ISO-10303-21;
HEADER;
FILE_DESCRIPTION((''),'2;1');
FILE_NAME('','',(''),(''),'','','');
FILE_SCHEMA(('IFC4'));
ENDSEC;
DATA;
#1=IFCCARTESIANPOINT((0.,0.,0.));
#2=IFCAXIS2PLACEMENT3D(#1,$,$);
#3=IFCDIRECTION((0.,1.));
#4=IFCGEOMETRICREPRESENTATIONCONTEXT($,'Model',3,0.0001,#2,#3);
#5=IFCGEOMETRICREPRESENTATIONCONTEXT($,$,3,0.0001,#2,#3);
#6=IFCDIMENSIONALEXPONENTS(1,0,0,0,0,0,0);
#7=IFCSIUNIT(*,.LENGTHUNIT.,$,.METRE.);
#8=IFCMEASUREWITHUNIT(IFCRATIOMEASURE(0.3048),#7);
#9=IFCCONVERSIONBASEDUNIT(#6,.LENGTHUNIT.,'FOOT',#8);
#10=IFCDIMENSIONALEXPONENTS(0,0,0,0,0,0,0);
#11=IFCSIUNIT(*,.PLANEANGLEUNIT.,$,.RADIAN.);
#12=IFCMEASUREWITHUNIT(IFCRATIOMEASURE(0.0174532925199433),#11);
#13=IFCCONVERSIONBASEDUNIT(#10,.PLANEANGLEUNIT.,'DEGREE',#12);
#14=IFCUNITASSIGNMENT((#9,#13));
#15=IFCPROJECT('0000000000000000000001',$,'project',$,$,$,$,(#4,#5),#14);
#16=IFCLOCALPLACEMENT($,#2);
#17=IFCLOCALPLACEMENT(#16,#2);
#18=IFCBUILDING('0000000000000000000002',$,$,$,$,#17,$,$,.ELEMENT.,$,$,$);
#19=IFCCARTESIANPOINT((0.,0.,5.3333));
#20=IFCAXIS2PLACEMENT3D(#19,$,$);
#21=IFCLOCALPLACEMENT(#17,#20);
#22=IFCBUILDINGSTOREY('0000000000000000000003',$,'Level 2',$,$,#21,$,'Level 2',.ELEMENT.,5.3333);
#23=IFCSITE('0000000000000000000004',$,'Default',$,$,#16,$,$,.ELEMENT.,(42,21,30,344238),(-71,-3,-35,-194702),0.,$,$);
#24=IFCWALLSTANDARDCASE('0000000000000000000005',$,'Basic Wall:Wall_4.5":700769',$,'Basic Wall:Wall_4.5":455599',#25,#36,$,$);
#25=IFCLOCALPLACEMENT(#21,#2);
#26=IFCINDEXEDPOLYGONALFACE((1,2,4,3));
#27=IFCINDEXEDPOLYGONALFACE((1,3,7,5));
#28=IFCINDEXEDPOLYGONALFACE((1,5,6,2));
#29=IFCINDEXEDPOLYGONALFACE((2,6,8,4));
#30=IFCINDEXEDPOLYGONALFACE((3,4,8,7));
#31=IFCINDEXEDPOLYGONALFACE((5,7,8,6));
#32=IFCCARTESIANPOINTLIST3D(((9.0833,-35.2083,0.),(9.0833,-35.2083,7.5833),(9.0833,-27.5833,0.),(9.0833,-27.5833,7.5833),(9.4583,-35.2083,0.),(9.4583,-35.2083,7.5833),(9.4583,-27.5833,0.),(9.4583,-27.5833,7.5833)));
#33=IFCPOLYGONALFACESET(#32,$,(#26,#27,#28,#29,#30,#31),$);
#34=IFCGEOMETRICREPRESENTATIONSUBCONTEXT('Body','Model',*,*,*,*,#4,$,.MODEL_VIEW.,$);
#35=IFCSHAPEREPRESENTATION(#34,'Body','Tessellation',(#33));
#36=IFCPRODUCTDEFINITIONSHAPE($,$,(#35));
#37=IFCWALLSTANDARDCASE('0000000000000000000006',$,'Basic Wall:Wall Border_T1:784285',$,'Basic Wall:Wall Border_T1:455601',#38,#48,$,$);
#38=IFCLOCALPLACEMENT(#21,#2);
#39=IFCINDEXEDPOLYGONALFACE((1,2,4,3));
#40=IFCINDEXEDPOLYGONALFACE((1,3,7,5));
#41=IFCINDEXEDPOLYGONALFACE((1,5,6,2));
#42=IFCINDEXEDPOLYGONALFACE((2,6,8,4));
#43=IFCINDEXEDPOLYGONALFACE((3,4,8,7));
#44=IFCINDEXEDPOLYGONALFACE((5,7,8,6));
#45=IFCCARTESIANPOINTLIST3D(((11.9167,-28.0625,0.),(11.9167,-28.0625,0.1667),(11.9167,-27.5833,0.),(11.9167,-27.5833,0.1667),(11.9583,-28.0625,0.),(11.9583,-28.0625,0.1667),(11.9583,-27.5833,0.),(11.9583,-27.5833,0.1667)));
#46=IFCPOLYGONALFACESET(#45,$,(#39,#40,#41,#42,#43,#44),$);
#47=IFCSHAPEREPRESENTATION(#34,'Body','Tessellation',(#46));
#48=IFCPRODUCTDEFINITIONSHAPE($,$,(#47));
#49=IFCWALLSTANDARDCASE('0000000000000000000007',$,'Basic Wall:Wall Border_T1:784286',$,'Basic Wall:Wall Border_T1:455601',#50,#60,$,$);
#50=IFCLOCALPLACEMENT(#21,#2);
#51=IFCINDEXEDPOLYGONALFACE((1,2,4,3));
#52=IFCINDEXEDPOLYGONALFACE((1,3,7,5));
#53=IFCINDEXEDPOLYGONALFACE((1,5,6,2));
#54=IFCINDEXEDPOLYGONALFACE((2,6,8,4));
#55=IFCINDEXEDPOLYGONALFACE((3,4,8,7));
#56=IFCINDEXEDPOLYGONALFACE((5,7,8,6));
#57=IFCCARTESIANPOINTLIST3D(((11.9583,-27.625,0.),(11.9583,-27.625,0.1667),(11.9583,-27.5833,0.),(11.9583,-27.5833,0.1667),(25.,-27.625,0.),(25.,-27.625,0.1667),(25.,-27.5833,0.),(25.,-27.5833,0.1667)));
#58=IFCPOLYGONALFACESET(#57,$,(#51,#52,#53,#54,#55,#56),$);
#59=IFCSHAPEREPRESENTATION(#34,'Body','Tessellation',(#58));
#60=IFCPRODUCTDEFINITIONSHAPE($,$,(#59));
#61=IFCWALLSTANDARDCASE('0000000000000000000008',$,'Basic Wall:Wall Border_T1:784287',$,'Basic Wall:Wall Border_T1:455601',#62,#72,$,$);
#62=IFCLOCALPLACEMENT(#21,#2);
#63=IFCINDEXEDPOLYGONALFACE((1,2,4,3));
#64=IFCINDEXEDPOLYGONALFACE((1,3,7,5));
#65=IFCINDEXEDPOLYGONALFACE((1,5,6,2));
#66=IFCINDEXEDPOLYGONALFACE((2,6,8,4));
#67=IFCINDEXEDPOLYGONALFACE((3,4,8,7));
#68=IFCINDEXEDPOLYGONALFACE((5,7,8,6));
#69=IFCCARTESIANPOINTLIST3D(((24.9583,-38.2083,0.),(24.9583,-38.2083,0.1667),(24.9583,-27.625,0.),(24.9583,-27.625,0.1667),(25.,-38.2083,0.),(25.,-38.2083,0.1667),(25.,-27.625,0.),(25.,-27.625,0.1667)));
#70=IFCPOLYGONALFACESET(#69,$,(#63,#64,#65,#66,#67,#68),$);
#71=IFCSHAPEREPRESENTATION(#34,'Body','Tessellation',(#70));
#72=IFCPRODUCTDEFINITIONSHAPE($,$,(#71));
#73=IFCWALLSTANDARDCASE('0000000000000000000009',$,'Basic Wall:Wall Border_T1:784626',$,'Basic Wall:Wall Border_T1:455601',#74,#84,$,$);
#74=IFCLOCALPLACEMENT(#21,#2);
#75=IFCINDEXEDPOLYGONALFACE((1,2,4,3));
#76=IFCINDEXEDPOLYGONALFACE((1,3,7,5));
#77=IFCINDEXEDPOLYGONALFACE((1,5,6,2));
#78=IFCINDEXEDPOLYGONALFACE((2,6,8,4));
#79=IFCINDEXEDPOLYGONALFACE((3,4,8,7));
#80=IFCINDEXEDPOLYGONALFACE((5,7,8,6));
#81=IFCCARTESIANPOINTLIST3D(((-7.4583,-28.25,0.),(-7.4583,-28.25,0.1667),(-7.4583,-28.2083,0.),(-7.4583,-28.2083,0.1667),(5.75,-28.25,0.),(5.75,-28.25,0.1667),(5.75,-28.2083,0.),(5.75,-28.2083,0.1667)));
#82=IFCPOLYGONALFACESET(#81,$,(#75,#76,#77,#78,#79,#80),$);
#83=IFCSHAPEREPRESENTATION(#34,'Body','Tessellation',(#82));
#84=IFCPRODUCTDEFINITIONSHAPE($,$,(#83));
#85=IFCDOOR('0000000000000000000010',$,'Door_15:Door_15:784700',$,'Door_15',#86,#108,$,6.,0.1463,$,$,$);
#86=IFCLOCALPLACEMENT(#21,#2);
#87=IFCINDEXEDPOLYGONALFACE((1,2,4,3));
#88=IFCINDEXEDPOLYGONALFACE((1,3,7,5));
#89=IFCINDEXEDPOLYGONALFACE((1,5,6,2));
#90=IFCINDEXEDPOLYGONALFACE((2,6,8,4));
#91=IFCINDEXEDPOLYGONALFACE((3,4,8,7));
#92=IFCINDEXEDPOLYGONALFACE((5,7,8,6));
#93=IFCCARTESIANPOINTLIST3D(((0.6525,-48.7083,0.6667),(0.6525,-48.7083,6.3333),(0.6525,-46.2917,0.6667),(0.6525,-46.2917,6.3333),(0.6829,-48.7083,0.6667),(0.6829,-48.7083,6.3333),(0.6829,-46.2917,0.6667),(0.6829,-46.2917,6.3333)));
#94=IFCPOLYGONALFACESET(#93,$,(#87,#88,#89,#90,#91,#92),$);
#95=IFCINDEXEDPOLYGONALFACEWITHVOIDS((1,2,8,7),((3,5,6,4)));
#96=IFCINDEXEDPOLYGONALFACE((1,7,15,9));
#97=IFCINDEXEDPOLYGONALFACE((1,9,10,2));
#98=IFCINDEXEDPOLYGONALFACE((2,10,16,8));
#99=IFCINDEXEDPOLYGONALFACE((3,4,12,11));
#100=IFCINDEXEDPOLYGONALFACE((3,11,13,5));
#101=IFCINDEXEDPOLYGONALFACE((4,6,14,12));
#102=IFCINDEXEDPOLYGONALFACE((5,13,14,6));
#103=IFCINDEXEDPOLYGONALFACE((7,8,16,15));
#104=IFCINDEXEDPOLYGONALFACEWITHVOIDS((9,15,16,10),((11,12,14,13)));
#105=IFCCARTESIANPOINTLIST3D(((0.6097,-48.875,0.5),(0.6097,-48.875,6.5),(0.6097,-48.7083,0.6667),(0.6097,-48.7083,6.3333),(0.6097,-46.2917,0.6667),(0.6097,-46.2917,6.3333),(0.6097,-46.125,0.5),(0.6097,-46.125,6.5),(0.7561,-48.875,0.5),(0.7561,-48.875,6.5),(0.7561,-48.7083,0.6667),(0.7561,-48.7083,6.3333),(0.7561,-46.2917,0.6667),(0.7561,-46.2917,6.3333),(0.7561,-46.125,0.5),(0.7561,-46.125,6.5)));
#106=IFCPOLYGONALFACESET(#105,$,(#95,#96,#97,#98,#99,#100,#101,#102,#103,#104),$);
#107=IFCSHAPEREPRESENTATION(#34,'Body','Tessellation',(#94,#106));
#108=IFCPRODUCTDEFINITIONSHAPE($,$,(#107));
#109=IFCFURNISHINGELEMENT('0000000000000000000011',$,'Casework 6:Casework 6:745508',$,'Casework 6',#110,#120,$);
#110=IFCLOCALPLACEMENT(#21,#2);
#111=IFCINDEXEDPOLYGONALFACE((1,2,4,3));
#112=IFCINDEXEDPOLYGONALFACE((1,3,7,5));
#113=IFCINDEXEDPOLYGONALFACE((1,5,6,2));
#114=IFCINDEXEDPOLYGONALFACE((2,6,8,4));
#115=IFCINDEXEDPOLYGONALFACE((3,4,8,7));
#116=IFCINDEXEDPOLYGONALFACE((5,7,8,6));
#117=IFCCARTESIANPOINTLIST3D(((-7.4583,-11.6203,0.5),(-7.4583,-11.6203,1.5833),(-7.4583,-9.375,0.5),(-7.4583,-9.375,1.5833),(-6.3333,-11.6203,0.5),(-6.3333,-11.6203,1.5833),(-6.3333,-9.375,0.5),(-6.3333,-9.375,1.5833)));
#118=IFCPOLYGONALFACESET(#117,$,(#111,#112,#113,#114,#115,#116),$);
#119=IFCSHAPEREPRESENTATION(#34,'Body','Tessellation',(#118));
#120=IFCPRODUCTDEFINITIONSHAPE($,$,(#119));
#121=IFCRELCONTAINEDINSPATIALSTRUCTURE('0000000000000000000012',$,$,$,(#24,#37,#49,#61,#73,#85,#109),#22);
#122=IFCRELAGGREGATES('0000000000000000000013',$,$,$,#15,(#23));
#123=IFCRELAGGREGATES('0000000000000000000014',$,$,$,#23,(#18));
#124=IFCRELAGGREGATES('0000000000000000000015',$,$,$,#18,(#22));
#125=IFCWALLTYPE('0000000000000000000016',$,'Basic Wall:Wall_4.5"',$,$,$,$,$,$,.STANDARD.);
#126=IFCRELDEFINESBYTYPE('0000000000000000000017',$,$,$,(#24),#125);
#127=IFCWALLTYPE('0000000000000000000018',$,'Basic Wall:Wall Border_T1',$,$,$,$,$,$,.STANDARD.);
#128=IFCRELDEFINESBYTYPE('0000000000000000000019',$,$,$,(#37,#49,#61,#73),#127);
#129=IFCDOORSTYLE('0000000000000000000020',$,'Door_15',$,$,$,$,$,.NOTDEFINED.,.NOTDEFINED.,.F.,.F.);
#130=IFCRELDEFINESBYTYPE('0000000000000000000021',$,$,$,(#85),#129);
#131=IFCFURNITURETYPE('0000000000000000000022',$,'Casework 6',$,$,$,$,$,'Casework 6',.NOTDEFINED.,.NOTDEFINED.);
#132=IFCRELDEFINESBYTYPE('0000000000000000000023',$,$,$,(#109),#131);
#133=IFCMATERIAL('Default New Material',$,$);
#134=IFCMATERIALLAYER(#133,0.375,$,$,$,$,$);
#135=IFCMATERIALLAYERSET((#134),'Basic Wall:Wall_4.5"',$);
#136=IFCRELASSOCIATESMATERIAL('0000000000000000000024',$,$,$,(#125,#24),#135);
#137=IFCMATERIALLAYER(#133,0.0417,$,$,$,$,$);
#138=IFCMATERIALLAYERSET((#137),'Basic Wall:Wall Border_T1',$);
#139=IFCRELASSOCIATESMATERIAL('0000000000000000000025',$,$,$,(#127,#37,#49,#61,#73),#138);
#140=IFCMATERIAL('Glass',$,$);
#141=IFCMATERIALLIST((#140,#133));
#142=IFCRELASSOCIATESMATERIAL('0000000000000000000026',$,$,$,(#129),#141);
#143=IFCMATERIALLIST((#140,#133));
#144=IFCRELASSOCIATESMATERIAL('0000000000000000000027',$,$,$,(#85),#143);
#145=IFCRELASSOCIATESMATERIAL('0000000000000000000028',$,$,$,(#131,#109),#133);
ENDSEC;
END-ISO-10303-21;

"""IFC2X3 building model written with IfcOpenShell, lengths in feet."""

from ifc_helpers import new_model, entity, si_unit, converted_unit, direction, frame, frame_2d, origin, place, context, subcontext, project, spatial, polyline, rectangle, outline, extrude, source, transform, mapped, material, material_list, layer, layer_set, layer_usage, type_object, type_shapes, element, save


model = new_model("IFC2X3")

# Units and contexts
model_context = context("Model", 3, precision=0.0001, world=origin(), true_north=direction((0.0, 1.0)))
context_of_model = context(None, 3, precision=0.0001, world=origin(), true_north=direction((0.0, 1.0)))
body_context = subcontext(model_context, "Body", "Model", "MODEL_VIEW")
ifc_project = project(units=[converted_unit("LENGTHUNIT", "FOOT", entity("IfcRatioMeasure", 0.3048), si_unit("LENGTHUNIT", "METRE"), dimensions=[1, 0, 0, 0, 0, 0, 0]), converted_unit("PLANEANGLEUNIT", "DEGREE", entity("IfcRatioMeasure", 0.0174532925199433), si_unit("PLANEANGLEUNIT", "RADIAN"), dimensions=[0, 0, 0, 0, 0, 0, 0])], contexts=[model_context, context_of_model])

# Site, building, storey
site_placement = place(None, origin())
site = spatial("IfcSite", under=ifc_project, at=site_placement, Name="Default", CompositionType="ELEMENT", RefLatitude=(42, 21, 30, 344238), RefLongitude=(-71, -3, -35, -194702), RefElevation=0.0)
building_placement = place(site_placement, origin())
building = spatial("IfcBuilding", under=site, at=building_placement, CompositionType="ELEMENT")
storey_placement = place(building_placement, frame((0.0, 0.0, 5.3333)))
storey = spatial("IfcBuildingStorey", under=building, at=storey_placement, Name="Level 2", LongName="Level 2", CompositionType="ELEMENT", Elevation=5.3333)

# Shared definitions
ifc_material_1 = material(Name="Default New Material")

# Shared definitions
ifc_material_2 = material(Name="Glass")

# Shared definitions
ifc_layer_1 = layer(ifc_material_1, 0.375)
ifc_layer_set_1 = layer_set([ifc_layer_1], Name="Basic Wall:Wall_4.5\"")
wall_type_1 = type_object("IfcWallType", Name="Basic Wall:Wall_4.5\"", PredefinedType="STANDARD", material=ifc_layer_set_1)

# Wall, opening
ifc_layer_usage_1 = layer_usage(ifc_layer_set_1, "AXIS2", "NEGATIVE", 0.1875)
wall_1_placement = place(storey_placement, frame((9.2708, -27.5833, 0.0), z_axis=(0.0, 0.0, 1.0), x_axis=(0.0, -1.0, 0.0)))
wall_1 = element("IfcWallStandardCase", 1, at=wall_1_placement, inside=storey, type_object=wall_type_1, material=ifc_layer_usage_1, Name="Basic Wall:Wall_4.5\":700769", ObjectType="Basic Wall:Wall_4.5\":455599", context=body_context, shape_type="SweptSolid", body=[
    extrude(rectangle(XDim=7.625, YDim=0.375, at=frame_2d((3.8125, 0.0), x_axis=(-1.0, 0.0))), origin(), (0.0, 0.0, 1.0), 7.5833),
])
opening_1_placement = place(wall_1_placement, frame((7.625, 0.1875, 0.0)))
element("IfcOpeningElement", 2, at=opening_1_placement, cuts=wall_1, ObjectType="Opening", context=body_context, shape_type="SweptSolid", body=[
    extrude(rectangle(XDim=6.6667, YDim=0.375, at=frame_2d((0.0, 0.0), x_axis=(0.0, 1.0))), frame((-0.1875, 0.0, 3.3333), z_axis=(0.0, 1.0, 0.0), x_axis=(1.0, 0.0, 0.0)), (0.0, 0.0, 1.0), 2.25),
])

# Walls
ifc_layer_2 = layer(ifc_material_1, 0.0417)
ifc_layer_set_2 = layer_set([ifc_layer_2], Name="Basic Wall:Wall Border_T1")
ifc_layer_usage_2 = layer_usage(ifc_layer_set_2, "AXIS2", "POSITIVE", -0.0208)
wall_type_2 = type_object("IfcWallType", Name="Basic Wall:Wall Border_T1", PredefinedType="STANDARD", material=ifc_layer_set_2)
wall_2_placement = place(storey_placement, frame((11.9375, -28.0625, 0.0), z_axis=(0.0, 0.0, 1.0), x_axis=(0.0, 1.0, 0.0)))
element("IfcWallStandardCase", 3, at=wall_2_placement, inside=storey, type_object=wall_type_2, material=ifc_layer_usage_2, Name="Basic Wall:Wall Border_T1:784285", ObjectType="Basic Wall:Wall Border_T1:455601", context=body_context, shape_type="SweptSolid", body=[
    extrude(rectangle(XDim=0.4792, YDim=0.0417, at=frame_2d((0.2396, 0.0), x_axis=(-1.0, 0.0))), origin(), (0.0, 0.0, 1.0), 0.1667),
])
ifc_layer_usage_3 = layer_usage(ifc_layer_set_2, "AXIS2", "POSITIVE", -0.0208)
wall_3_placement = place(storey_placement, frame((11.9583, -27.6042, 0.0)))
element("IfcWallStandardCase", 4, at=wall_3_placement, inside=storey, type_object=wall_type_2, material=ifc_layer_usage_3, Name="Basic Wall:Wall Border_T1:784286", ObjectType="Basic Wall:Wall Border_T1:455601", context=body_context, shape_type="SweptSolid", body=[
    extrude(rectangle(XDim=13.0417, YDim=0.0417, at=frame_2d((6.5208, 0.0), x_axis=(-1.0, 0.0))), origin(), (0.0, 0.0, 1.0), 0.1667),
])
ifc_layer_usage_4 = layer_usage(ifc_layer_set_2, "AXIS2", "POSITIVE", -0.0208)
wall_4_placement = place(storey_placement, frame((24.9792, -27.625, 0.0), z_axis=(0.0, 0.0, 1.0), x_axis=(0.0, -1.0, 0.0)))
element("IfcWallStandardCase", 5, at=wall_4_placement, inside=storey, type_object=wall_type_2, material=ifc_layer_usage_4, Name="Basic Wall:Wall Border_T1:784287", ObjectType="Basic Wall:Wall Border_T1:455601", context=body_context, shape_type="SweptSolid", body=[
    extrude(rectangle(XDim=10.5833, YDim=0.0417, at=frame_2d((5.2917, 0.0), x_axis=(-1.0, 0.0))), origin(), (0.0, 0.0, 1.0), 0.1667),
])
ifc_layer_usage_5 = layer_usage(ifc_layer_set_2, "AXIS2", "NEGATIVE", 0.0208)
wall_5_placement = place(storey_placement, frame((5.75, -28.2292, 0.0), z_axis=(0.0, 0.0, 1.0), x_axis=(-1.0, 0.0, 0.0)))
element("IfcWallStandardCase", 6, at=wall_5_placement, inside=storey, type_object=wall_type_2, material=ifc_layer_usage_5, Name="Basic Wall:Wall Border_T1:784626", ObjectType="Basic Wall:Wall Border_T1:455601", context=body_context, shape_type="SweptSolid", body=[
    extrude(rectangle(XDim=13.2083, YDim=0.0417, at=frame_2d((6.6042, 0.0), x_axis=(-1.0, 0.0))), origin(), (0.0, 0.0, 1.0), 0.1667),
])

# Door
ifc_material_list_1 = material_list([ifc_material_2, ifc_material_1])
ifc_material_list_2 = material_list([ifc_material_2, ifc_material_1])
door_style_1 = type_object("IfcDoorStyle", Name="Door_15", ConstructionType="NOTDEFINED", OperationType="NOTDEFINED", ParameterTakesPrecedence=False, Sizeable=False, material=ifc_material_list_2)
shared_shape_1 = source(origin(), body_context, "Body", "SweptSolid", [
    extrude(rectangle(XDim=2.4167, YDim=0.0304, at=frame_2d((0.0, 0.0), x_axis=(1.0, 0.0))), frame((0.6677, -47.5, 6.0), z_axis=(0.0, 0.0, 1.0), x_axis=(0.0, -1.0, 0.0)), (0.0, 0.0, 1.0), 5.6667),
    extrude(outline(polyline([(-3.0, -1.375), (3.0, -1.375), (3.0, 1.375), (-3.0, 1.375), (-3.0, -1.375)]), holes=[polyline([(2.8333, 1.2083), (2.8333, -1.2083), (-2.8333, -1.2083), (-2.8333, 1.2083), (2.8333, 1.2083)])]), frame((0.6097, -47.5, 8.8333), z_axis=(1.0, 0.0, 0.0), x_axis=(0.0, 0.0, -1.0)), (0.0, 0.0, 1.0), 0.1463),
])
type_shapes(door_style_1, [shared_shape_1])
door_1_placement = place(storey_placement, frame((0.0, 0.0, -5.3333)))
element("IfcDoor", 7, at=door_1_placement, inside=storey, type_object=door_style_1, material=ifc_material_list_1, Name="Door_15:Door_15:784700", ObjectType="Door_15", OverallHeight=6.0, OverallWidth=0.1463, context=body_context, shape_type="MappedRepresentation", body=[
    mapped(shared_shape_1, transform((0.0, 0.0, 0.0), scale=1.0)),
])

# Furnishing element
furniture_type_1 = type_object("IfcFurnitureType", Name="Casework 6", ElementType="Casework 6", AssemblyPlace="NOTDEFINED", material=ifc_material_1)
shared_shape_2 = source(origin(), body_context, "Body", "SweptSolid", [
    extrude(rectangle(XDim=1.125, YDim=2.2453, at=frame_2d((0.0, 0.0), x_axis=(1.0, 0.0))), frame((0.5625, 1.1226, 0.0), z_axis=(0.0, 0.0, 1.0), x_axis=(-1.0, 0.0, 0.0)), (0.0, 0.0, 1.0), 1.0833),
])
type_shapes(furniture_type_1, [shared_shape_2])
furnishing_1_placement = place(storey_placement, frame((-7.4583, -11.6203, 0.5)))
element("IfcFurnishingElement", 8, at=furnishing_1_placement, inside=storey, type_object=furniture_type_1, material=ifc_material_1, Name="Casework 6:Casework 6:745508", ObjectType="Casework 6", context=body_context, shape_type="MappedRepresentation", body=[
    mapped(shared_shape_2, transform((0.0, 0.0, 0.0), scale=1.0)),
])

save(model, "model.ifc")
